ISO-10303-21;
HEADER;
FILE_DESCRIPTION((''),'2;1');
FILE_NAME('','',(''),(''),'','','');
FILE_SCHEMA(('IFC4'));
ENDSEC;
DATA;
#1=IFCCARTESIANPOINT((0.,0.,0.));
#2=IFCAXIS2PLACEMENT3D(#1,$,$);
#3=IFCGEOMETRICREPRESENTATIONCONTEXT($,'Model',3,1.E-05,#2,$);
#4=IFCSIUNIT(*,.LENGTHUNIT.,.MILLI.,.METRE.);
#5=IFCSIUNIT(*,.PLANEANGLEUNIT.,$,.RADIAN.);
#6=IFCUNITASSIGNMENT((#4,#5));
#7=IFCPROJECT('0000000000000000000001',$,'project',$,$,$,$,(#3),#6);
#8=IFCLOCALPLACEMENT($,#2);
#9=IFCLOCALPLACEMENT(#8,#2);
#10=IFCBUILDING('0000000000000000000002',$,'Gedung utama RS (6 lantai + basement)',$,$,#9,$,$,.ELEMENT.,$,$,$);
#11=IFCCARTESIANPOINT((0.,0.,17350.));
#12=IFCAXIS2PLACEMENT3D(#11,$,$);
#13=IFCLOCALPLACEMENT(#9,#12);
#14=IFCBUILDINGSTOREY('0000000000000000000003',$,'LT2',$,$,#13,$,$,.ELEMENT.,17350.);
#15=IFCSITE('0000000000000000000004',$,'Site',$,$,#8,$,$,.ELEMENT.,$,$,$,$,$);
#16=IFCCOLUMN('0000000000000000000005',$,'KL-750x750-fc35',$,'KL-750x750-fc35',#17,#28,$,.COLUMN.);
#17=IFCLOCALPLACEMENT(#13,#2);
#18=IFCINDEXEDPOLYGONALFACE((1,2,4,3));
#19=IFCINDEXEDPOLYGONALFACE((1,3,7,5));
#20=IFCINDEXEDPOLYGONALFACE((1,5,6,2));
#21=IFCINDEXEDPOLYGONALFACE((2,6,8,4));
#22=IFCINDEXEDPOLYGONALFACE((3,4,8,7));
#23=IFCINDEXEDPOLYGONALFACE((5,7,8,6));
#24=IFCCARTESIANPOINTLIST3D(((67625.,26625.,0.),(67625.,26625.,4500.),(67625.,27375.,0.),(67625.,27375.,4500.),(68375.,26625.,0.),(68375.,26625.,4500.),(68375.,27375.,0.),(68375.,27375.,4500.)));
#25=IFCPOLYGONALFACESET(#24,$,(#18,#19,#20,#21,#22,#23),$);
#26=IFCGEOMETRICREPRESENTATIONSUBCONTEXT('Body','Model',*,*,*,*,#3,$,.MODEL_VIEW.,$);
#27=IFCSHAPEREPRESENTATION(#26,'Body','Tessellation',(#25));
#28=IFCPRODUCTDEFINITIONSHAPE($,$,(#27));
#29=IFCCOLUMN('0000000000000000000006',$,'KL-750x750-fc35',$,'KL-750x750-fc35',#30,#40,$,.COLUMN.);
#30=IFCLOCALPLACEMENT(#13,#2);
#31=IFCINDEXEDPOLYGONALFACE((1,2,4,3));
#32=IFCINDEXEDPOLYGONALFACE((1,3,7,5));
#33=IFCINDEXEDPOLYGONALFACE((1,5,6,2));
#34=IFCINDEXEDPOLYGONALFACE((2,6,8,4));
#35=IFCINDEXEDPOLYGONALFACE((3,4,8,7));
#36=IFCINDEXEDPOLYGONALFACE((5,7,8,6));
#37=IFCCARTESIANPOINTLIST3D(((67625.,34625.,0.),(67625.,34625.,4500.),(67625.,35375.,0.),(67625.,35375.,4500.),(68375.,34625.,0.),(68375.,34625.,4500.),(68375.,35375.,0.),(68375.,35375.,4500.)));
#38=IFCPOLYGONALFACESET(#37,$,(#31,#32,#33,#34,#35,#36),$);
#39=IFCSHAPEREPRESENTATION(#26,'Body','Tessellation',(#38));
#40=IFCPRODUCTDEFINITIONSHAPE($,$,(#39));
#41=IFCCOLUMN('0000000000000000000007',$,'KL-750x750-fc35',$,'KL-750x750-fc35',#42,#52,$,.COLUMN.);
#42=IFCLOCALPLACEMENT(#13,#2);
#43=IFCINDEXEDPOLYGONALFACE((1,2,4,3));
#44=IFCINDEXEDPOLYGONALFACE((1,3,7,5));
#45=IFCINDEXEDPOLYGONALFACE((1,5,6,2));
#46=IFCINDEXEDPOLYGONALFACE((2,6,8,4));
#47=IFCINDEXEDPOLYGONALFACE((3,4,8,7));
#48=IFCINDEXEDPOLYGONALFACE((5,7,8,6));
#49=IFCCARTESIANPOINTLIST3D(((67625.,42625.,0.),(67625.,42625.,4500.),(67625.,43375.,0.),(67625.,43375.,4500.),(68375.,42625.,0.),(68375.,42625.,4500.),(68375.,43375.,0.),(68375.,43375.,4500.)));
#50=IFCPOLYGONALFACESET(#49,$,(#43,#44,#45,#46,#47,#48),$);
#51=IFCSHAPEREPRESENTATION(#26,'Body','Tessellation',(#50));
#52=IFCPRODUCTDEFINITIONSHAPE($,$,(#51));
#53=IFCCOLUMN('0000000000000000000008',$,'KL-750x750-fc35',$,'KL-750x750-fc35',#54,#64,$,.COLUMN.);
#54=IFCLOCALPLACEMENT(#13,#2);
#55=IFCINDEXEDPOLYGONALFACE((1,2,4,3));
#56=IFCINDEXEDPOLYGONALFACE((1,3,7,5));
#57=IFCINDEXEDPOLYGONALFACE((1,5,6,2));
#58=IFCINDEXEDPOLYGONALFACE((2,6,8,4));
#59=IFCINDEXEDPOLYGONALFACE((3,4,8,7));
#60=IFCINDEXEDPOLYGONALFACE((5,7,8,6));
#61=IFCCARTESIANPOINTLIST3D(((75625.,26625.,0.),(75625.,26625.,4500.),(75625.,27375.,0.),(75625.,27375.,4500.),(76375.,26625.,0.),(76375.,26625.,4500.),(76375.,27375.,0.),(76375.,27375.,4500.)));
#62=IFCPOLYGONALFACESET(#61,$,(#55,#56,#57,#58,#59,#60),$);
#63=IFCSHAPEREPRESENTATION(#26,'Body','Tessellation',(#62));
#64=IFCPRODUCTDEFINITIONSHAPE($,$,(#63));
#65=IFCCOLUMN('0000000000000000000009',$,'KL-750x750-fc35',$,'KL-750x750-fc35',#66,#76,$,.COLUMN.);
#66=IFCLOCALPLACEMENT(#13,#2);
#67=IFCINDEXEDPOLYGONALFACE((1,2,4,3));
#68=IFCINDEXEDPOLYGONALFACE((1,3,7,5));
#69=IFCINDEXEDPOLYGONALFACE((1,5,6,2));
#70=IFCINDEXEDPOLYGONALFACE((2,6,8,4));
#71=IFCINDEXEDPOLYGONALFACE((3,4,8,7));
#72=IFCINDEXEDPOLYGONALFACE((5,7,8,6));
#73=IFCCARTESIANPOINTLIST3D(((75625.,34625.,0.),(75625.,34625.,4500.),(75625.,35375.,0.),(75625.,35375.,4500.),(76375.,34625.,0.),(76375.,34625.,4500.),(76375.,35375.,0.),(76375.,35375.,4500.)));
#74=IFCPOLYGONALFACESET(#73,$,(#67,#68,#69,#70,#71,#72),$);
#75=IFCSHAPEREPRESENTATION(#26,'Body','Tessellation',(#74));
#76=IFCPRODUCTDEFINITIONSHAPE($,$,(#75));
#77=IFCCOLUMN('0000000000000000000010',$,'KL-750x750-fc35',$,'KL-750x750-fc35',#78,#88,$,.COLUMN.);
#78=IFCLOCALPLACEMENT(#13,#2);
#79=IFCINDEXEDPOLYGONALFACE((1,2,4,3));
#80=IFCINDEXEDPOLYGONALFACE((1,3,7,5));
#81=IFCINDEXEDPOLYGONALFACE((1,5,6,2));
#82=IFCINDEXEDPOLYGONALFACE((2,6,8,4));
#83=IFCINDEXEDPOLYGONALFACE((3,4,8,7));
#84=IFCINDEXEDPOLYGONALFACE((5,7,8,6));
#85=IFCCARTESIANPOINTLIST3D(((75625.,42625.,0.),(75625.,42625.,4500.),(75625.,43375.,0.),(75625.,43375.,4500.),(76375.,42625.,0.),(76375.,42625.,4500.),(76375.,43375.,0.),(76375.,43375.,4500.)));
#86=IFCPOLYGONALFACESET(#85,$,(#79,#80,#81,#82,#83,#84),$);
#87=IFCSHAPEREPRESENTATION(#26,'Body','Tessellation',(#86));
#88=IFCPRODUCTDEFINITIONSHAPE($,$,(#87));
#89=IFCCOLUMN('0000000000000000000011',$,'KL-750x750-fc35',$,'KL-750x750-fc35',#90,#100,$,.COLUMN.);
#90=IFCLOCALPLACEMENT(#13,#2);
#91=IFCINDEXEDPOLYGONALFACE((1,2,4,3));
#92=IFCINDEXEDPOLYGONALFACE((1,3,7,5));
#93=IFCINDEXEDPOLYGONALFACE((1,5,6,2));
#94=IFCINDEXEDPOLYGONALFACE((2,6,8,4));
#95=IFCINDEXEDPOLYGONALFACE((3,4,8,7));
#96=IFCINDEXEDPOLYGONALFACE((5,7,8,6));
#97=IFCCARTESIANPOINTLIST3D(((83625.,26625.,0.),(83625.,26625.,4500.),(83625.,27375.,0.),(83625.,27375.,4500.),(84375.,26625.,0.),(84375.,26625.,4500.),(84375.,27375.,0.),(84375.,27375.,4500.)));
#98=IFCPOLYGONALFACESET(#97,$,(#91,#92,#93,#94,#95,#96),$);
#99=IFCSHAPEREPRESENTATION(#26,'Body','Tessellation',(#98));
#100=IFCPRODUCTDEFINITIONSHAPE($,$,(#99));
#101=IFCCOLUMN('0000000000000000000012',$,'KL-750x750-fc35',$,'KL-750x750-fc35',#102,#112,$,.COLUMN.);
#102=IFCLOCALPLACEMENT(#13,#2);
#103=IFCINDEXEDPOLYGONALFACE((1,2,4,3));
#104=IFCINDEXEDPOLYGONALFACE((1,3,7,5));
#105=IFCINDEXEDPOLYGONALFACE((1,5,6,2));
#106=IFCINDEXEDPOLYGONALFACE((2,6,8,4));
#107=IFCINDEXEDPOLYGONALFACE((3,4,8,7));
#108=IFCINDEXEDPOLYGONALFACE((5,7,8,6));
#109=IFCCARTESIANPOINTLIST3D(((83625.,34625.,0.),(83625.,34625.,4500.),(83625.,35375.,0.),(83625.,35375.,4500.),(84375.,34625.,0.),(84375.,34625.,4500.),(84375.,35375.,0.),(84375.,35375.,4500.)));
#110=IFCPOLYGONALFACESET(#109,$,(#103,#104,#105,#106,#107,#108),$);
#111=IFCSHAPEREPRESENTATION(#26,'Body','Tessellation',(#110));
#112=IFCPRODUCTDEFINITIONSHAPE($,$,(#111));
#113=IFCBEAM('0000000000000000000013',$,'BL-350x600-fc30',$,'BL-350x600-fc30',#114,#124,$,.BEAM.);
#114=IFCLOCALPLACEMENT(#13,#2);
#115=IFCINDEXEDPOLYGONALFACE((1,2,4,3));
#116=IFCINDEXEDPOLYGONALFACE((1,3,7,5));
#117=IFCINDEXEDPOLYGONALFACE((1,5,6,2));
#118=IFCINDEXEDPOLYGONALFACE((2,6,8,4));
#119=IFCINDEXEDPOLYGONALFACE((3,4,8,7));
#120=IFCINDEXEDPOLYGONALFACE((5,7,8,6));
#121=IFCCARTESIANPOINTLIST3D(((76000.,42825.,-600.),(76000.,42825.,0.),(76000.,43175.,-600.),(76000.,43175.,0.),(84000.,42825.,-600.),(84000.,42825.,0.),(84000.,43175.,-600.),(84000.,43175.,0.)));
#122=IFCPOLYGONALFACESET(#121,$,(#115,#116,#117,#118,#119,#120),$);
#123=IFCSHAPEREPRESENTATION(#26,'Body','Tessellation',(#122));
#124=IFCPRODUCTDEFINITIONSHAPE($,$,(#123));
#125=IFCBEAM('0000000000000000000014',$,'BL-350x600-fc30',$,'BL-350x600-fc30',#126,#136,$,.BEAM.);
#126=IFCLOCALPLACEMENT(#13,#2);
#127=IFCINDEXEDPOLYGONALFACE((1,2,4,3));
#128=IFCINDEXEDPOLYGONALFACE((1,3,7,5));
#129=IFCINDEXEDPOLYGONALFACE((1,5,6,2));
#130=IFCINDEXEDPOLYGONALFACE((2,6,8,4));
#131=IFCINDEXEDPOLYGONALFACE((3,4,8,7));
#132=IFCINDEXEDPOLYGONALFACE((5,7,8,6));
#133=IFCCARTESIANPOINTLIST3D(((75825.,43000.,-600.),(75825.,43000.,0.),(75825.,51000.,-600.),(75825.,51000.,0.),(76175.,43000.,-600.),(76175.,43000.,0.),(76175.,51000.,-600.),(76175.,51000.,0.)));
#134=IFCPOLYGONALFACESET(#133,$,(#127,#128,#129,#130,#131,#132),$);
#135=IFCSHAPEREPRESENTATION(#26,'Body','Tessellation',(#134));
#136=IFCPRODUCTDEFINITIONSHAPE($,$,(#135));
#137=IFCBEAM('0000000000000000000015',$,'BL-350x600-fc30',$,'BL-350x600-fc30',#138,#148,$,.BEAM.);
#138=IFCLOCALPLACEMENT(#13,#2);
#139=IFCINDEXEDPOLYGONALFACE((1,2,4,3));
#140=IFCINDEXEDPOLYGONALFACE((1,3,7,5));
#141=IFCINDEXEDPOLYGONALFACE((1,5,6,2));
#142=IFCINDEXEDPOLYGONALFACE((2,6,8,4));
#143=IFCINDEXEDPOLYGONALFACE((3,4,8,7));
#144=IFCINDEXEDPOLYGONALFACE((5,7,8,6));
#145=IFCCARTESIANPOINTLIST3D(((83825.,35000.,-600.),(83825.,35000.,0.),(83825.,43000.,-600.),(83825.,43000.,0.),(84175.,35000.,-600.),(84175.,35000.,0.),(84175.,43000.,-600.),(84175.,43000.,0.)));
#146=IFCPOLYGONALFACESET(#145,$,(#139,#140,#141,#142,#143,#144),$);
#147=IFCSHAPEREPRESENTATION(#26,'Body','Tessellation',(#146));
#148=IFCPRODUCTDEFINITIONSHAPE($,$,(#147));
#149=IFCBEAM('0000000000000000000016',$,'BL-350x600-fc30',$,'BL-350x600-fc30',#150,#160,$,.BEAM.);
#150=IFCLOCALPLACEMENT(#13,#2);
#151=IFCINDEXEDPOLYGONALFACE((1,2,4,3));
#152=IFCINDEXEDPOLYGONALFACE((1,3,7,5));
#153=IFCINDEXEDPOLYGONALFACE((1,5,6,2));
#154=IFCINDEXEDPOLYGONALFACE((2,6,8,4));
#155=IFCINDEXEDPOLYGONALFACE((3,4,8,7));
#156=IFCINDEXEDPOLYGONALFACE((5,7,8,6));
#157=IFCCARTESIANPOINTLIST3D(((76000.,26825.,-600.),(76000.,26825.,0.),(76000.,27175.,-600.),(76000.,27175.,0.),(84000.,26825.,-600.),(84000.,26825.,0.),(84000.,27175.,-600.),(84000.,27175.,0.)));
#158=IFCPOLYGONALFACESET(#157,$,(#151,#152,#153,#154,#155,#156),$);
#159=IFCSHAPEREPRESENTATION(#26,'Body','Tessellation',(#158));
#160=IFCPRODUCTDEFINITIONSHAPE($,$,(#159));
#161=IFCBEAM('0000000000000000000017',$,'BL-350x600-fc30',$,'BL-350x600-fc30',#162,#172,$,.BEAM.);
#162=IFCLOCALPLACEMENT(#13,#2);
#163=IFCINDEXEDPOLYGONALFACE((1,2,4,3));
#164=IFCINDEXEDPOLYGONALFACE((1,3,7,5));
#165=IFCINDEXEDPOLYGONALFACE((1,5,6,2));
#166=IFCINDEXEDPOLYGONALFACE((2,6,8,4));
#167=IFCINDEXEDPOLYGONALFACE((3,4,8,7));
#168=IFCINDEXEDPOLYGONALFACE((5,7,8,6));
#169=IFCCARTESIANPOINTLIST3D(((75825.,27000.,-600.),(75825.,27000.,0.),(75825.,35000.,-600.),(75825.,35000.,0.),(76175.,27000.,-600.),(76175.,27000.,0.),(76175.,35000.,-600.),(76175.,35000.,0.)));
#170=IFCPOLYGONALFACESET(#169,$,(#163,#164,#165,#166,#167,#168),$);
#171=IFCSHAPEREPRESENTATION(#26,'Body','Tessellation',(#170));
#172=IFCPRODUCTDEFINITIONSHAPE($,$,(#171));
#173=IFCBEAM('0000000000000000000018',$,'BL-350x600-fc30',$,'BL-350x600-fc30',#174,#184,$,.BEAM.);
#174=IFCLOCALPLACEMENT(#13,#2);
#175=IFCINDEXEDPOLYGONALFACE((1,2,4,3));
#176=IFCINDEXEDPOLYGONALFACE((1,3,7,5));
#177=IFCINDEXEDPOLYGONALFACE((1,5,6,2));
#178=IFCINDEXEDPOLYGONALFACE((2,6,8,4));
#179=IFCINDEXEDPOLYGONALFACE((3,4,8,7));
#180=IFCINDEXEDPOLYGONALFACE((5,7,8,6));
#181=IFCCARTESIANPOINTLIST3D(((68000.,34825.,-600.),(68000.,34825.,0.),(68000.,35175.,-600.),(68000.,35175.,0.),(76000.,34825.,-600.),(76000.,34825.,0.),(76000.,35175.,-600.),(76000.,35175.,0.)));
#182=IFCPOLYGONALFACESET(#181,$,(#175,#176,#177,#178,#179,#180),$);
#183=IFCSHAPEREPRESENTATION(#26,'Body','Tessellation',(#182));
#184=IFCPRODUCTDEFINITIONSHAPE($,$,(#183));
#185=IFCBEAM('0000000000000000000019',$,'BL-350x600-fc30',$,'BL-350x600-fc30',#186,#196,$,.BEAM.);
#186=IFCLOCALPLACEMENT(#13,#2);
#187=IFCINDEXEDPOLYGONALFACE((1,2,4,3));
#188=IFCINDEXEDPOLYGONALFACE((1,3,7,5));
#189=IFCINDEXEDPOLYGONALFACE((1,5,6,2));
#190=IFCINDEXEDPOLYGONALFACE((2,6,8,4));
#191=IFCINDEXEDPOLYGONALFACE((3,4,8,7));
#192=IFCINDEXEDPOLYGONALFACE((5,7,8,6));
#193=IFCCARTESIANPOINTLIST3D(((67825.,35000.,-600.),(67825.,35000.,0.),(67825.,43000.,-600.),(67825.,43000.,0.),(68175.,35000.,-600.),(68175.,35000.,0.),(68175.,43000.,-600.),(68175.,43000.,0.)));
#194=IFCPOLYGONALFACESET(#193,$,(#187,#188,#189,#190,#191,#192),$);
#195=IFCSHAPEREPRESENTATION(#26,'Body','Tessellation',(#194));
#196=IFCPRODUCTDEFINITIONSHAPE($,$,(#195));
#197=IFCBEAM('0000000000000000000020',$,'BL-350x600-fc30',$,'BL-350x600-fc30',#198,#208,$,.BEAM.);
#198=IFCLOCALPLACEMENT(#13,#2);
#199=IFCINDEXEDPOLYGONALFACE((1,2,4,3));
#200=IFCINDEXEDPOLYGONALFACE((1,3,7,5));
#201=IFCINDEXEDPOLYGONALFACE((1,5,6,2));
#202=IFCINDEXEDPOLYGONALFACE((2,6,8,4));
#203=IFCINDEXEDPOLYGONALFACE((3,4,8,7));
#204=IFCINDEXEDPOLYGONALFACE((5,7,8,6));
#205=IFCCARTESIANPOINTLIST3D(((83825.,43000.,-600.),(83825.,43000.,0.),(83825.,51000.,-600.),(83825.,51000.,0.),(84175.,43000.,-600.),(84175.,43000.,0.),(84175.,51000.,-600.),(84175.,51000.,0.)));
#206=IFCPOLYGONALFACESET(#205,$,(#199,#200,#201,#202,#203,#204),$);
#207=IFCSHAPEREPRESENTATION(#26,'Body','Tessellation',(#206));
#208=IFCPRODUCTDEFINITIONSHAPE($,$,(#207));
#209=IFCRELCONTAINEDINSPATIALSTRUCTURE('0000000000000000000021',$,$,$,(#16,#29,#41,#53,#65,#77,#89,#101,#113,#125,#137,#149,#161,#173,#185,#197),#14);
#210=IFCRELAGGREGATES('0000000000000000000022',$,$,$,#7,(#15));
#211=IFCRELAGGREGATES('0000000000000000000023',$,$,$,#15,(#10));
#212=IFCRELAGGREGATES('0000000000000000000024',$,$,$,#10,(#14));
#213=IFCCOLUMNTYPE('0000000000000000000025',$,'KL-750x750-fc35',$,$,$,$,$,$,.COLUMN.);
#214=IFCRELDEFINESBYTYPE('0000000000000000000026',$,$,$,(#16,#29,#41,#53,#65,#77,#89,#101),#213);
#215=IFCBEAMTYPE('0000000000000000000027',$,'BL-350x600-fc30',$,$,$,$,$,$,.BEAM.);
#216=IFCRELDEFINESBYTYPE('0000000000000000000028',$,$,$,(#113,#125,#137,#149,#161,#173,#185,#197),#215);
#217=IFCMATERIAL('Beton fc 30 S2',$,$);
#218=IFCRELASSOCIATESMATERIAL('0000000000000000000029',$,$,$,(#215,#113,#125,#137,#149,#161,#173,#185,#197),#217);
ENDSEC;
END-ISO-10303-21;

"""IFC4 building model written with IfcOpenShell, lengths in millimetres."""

from ifc_helpers import new_model, si_unit, frame, origin, origin_2d, place, context, subcontext, project, spatial, rectangle, extrude, material, material_profile, profile_set, profile_usage, type_object, element, save


model = new_model("IFC4")

# Units and contexts
model_context = context("Model", 3, precision=1e-05, world=origin())
body_context = subcontext(model_context, "Body", "Model", "MODEL_VIEW")
ifc_project = project(units=[si_unit("LENGTHUNIT", "METRE", prefix="MILLI"), si_unit("PLANEANGLEUNIT", "RADIAN")], contexts=[model_context])

# Site, building, storey
site_placement = place(None, origin())
site = spatial("IfcSite", under=ifc_project, at=site_placement, Name="Site", CompositionType="ELEMENT")
building_placement = place(site_placement, origin())
building = spatial("IfcBuilding", under=site, at=building_placement, Name="Gedung utama RS (6 lantai + basement)", CompositionType="ELEMENT")
storey_placement = place(building_placement, frame((0.0, 0.0, 17350.0)))
storey = spatial("IfcBuildingStorey", under=building, at=storey_placement, Name="LT2", CompositionType="ELEMENT", Elevation=17350.0)

# Columns
ifc_material_profile_1 = material_profile(None, rectangle(XDim=750.0, YDim=750.0, at=origin_2d()), Name="KL-750x750-fc35")
ifc_profile_set_1 = profile_set([ifc_material_profile_1], Name="KL-750x750-fc35")
ifc_profile_usage_1 = profile_usage(ifc_profile_set_1, cardinal=5)
column_type = type_object("IfcColumnType", Name="KL-750x750-fc35", PredefinedType="COLUMN", material=ifc_profile_set_1)
for number, where, z_axis, x_axis, name in (
    (1, (68000.0, 27000.0, 0.0), (0.0, 0.0, 1.0), (1.0, 0.0, 0.0), "KL-750x750-fc35"),
    (2, (68000.0, 35000.0, 0.0), (0.0, 0.0, 1.0), (1.0, 0.0, 0.0), "KL-750x750-fc35"),
    (3, (68000.0, 43000.0, 0.0), (0.0, 0.0, 1.0), (1.0, 0.0, 0.0), "KL-750x750-fc35"),
    (4, (76000.0, 27000.0, 0.0), (0.0, 0.0, 1.0), (1.0, 0.0, 0.0), "KL-750x750-fc35"),
    (5, (76000.0, 35000.0, 0.0), (0.0, 0.0, 1.0), (1.0, 0.0, 0.0), "KL-750x750-fc35"),
    (6, (76000.0, 43000.0, 0.0), (0.0, 0.0, 1.0), (1.0, 0.0, 0.0), "KL-750x750-fc35"),
    (7, (84000.0, 27000.0, 0.0), (0.0, 0.0, 1.0), (1.0, 0.0, 0.0), "KL-750x750-fc35"),
    (8, (84000.0, 35000.0, 0.0), (0.0, 0.0, 1.0), (1.0, 0.0, 0.0), "KL-750x750-fc35"),
):
    element("IfcColumn", number, at=place(storey_placement, frame(where, z_axis=z_axis, x_axis=x_axis)), inside=storey, type_object=column_type, material=ifc_profile_usage_1, Name=name, ObjectType="KL-750x750-fc35", PredefinedType="COLUMN", context=body_context, shape_type="SweptSolid", body=[
        extrude(rectangle(XDim=750.0, YDim=750.0, at=origin_2d()), origin(), (0.0, 0.0, 1.0), 4500.0),
    ])

# Beams
ifc_material_1 = material(Name="Beton fc 30 S2")
ifc_material_profile_2 = material_profile(ifc_material_1, rectangle(XDim=350.0, YDim=600.0, at=origin_2d()), Name="BL-350x600-fc30")
ifc_profile_set_2 = profile_set([ifc_material_profile_2], Name="BL-350x600-fc30")
ifc_profile_usage_2 = profile_usage(ifc_profile_set_2, cardinal=8)
beam_type = type_object("IfcBeamType", Name="BL-350x600-fc30", PredefinedType="BEAM", material=ifc_profile_set_2)
beam_1_placement = place(storey_placement, frame((76000.0, 43000.0, -300.0)))
element("IfcBeam", 9, at=beam_1_placement, inside=storey, type_object=beam_type, material=ifc_profile_usage_2, Name="BL-350x600-fc30", ObjectType="BL-350x600-fc30", PredefinedType="BEAM", context=body_context, shape_type="SweptSolid", body=[
    extrude(rectangle(XDim=350.0, YDim=600.0, at=origin_2d()), frame((0.0, 0.0, 0.0), z_axis=(1.0, 0.0, 0.0), x_axis=(0.0, 1.0, 0.0)), (0.0, 0.0, 1.0), 8000.0),
])
for number, where, name in (
    (10, (76000.0, 43000.0, -300.0), "BL-350x600-fc30"),
    (11, (84000.0, 35000.0, -300.0), "BL-350x600-fc30"),
):
    element("IfcBeam", number, at=place(storey_placement, frame(where)), inside=storey, type_object=beam_type, material=ifc_profile_usage_2, Name=name, ObjectType="BL-350x600-fc30", PredefinedType="BEAM", context=body_context, shape_type="SweptSolid", body=[
        extrude(rectangle(XDim=350.0, YDim=600.0, at=origin_2d()), frame((0.0, 0.0, 0.0), z_axis=(0.0, 1.0, 0.0), x_axis=(-1.0, 0.0, 0.0)), (0.0, 0.0, 1.0), 8000.0),
    ])
beam_2_placement = place(storey_placement, frame((76000.0, 27000.0, -300.0)))
element("IfcBeam", 12, at=beam_2_placement, inside=storey, type_object=beam_type, material=ifc_profile_usage_2, Name="BL-350x600-fc30", ObjectType="BL-350x600-fc30", PredefinedType="BEAM", context=body_context, shape_type="SweptSolid", body=[
    extrude(rectangle(XDim=350.0, YDim=600.0, at=origin_2d()), frame((0.0, 0.0, 0.0), z_axis=(1.0, 0.0, 0.0), x_axis=(0.0, 1.0, 0.0)), (0.0, 0.0, 1.0), 8000.0),
])
beam_3_placement = place(storey_placement, frame((76000.0, 27000.0, -300.0)))
element("IfcBeam", 13, at=beam_3_placement, inside=storey, type_object=beam_type, material=ifc_profile_usage_2, Name="BL-350x600-fc30", ObjectType="BL-350x600-fc30", PredefinedType="BEAM", context=body_context, shape_type="SweptSolid", body=[
    extrude(rectangle(XDim=350.0, YDim=600.0, at=origin_2d()), frame((0.0, 0.0, 0.0), z_axis=(0.0, 1.0, 0.0), x_axis=(-1.0, 0.0, 0.0)), (0.0, 0.0, 1.0), 8000.0),
])
beam_4_placement = place(storey_placement, frame((68000.0, 35000.0, -300.0)))
element("IfcBeam", 14, at=beam_4_placement, inside=storey, type_object=beam_type, material=ifc_profile_usage_2, Name="BL-350x600-fc30", ObjectType="BL-350x600-fc30", PredefinedType="BEAM", context=body_context, shape_type="SweptSolid", body=[
    extrude(rectangle(XDim=350.0, YDim=600.0, at=origin_2d()), frame((0.0, 0.0, 0.0), z_axis=(1.0, 0.0, 0.0), x_axis=(0.0, 1.0, 0.0)), (0.0, 0.0, 1.0), 8000.0),
])
for number, where, name in (
    (15, (68000.0, 35000.0, -300.0), "BL-350x600-fc30"),
    (16, (84000.0, 43000.0, -300.0), "BL-350x600-fc30"),
):
    element("IfcBeam", number, at=place(storey_placement, frame(where)), inside=storey, type_object=beam_type, material=ifc_profile_usage_2, Name=name, ObjectType="BL-350x600-fc30", PredefinedType="BEAM", context=body_context, shape_type="SweptSolid", body=[
        extrude(rectangle(XDim=350.0, YDim=600.0, at=origin_2d()), frame((0.0, 0.0, 0.0), z_axis=(0.0, 1.0, 0.0), x_axis=(-1.0, 0.0, 0.0)), (0.0, 0.0, 1.0), 8000.0),
    ])

save(model, "model.ifc")
